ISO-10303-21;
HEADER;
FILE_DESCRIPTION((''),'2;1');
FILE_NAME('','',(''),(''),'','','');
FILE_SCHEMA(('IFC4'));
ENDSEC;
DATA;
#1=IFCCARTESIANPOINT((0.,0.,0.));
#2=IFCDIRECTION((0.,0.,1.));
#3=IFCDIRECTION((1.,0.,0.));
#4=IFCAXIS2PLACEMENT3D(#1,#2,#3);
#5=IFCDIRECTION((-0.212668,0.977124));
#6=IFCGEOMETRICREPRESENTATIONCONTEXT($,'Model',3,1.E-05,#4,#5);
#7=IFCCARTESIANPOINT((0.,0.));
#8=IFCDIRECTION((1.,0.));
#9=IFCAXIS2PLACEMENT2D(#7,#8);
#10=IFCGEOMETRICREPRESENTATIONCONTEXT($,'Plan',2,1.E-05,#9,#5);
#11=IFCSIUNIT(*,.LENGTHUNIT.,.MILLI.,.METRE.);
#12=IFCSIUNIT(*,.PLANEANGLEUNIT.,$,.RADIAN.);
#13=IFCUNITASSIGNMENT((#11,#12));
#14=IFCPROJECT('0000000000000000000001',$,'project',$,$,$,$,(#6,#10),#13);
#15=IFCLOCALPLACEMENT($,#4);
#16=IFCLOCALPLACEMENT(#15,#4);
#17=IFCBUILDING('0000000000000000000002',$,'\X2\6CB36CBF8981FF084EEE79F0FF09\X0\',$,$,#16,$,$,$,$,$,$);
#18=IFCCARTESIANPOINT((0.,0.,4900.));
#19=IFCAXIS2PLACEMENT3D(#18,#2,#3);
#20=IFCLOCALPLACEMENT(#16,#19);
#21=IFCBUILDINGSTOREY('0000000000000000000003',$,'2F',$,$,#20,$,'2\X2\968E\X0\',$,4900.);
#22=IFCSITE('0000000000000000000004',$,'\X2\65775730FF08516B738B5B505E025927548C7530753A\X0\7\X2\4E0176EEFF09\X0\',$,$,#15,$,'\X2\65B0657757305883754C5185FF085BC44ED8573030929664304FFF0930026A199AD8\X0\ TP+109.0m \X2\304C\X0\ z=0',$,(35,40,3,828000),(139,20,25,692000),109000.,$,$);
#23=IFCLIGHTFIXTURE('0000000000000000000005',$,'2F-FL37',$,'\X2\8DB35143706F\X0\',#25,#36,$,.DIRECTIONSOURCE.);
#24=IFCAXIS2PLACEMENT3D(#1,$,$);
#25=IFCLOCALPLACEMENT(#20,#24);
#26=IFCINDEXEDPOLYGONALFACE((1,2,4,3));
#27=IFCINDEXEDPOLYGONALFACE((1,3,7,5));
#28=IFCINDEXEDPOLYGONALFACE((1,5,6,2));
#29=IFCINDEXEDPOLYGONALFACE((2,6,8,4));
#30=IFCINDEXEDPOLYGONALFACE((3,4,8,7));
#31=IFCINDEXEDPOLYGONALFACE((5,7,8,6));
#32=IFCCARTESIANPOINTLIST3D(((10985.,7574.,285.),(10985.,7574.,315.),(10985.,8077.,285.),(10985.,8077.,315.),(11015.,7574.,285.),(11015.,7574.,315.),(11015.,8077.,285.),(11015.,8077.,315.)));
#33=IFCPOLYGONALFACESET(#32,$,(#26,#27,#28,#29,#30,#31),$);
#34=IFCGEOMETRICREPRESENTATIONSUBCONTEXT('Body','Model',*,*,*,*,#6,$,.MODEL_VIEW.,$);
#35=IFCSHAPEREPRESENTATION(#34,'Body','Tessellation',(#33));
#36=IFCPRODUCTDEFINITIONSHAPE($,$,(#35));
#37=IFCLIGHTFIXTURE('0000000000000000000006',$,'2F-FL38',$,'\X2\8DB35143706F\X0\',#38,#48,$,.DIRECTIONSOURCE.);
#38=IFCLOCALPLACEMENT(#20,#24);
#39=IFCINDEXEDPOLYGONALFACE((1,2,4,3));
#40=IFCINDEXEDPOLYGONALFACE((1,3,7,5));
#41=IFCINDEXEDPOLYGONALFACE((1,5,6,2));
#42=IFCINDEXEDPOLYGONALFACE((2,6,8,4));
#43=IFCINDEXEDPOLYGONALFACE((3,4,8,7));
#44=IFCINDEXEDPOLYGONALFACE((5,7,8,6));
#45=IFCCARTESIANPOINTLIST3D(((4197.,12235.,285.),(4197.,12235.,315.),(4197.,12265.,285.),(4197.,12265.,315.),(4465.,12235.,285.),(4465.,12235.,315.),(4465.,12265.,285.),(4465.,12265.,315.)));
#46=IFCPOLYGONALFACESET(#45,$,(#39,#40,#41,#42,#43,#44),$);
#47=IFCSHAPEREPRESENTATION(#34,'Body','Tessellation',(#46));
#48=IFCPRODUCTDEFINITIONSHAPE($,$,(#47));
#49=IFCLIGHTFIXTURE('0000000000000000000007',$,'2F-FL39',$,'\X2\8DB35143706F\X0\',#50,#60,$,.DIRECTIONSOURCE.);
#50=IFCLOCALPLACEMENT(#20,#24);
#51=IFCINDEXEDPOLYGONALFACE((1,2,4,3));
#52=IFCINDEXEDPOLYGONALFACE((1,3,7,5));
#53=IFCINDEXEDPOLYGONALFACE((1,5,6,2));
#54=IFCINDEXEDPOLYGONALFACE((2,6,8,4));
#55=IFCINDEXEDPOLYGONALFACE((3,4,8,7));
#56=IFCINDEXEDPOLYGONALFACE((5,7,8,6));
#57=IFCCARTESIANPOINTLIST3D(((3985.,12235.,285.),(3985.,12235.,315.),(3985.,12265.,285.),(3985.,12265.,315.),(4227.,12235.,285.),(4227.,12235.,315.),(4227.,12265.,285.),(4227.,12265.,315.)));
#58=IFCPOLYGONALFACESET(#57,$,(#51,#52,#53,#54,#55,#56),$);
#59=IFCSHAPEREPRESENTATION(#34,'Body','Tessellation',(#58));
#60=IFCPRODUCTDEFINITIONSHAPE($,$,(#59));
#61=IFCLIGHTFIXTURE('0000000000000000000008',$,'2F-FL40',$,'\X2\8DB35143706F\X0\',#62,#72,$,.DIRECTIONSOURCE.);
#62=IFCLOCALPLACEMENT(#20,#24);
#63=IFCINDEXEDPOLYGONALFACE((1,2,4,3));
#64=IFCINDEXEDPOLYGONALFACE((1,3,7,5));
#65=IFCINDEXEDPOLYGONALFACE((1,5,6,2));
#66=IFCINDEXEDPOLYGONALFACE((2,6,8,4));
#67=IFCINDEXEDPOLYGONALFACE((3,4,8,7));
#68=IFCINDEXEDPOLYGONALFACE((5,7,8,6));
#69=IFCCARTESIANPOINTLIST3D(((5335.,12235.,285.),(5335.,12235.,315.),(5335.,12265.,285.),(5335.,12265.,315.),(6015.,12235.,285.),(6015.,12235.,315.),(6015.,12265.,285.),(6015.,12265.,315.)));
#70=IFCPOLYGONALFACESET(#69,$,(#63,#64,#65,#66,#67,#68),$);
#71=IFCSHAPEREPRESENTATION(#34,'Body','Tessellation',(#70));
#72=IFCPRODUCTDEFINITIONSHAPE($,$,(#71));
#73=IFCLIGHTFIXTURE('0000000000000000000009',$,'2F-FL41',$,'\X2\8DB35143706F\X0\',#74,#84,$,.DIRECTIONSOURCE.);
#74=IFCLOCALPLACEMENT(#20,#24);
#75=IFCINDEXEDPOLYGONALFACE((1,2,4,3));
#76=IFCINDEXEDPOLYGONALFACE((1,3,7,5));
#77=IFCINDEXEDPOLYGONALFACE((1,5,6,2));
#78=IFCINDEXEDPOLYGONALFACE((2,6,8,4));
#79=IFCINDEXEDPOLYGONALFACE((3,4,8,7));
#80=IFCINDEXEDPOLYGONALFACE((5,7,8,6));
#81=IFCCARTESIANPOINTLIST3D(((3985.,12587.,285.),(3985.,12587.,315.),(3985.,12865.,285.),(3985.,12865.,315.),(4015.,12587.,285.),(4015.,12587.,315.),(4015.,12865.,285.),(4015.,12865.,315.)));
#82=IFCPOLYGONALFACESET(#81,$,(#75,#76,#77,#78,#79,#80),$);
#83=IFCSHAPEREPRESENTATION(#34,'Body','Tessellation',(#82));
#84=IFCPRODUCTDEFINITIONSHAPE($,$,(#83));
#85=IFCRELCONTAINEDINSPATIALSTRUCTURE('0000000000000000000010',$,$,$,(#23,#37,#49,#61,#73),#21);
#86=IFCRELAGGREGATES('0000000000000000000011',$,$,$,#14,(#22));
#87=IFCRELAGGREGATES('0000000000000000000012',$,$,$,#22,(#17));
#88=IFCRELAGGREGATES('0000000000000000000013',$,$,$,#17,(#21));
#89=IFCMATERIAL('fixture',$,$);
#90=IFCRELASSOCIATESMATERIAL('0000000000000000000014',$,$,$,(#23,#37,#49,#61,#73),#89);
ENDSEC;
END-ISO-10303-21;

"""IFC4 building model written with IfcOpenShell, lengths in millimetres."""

from ifc_helpers import new_model, si_unit, direction, frame, frame_2d, origin_with_axes, origin_2d_with_axis, place, context, subcontext, project, spatial, rectangle, extrude, material, element, save


model = new_model("IFC4")

# Units and contexts
model_context = context("Model", 3, precision=1e-05, world=origin_with_axes(), true_north=direction((-0.212668, 0.977124)))
plan_context = context("Plan", 2, precision=1e-05, world=origin_2d_with_axis(), true_north=direction((-0.212668, 0.977124)))
body_context = subcontext(model_context, "Body", "Model", "MODEL_VIEW")
ifc_project = project(units=[si_unit("LENGTHUNIT", "METRE", prefix="MILLI"), si_unit("PLANEANGLEUNIT", "RADIAN")], contexts=[model_context, plan_context])

# Site, building, storey
site_placement = place(None, origin_with_axes())
site = spatial("IfcSite", under=ifc_project, at=site_placement, Name="敷地（八王子市大和田町7丁目）", LongName="新敷地境界内（寄付地を除く）。標高 TP+109.0m が z=0", RefLatitude=(35, 40, 3, 828000), RefLongitude=(139, 20, 25, 692000), RefElevation=109000.0)
building_placement = place(site_placement, origin_with_axes())
building = spatial("IfcBuilding", under=site, at=building_placement, Name="河沿要（仮称）")
storey_placement = place(building_placement, frame((0.0, 0.0, 4900.0), z_axis=(0.0, 0.0, 1.0), x_axis=(1.0, 0.0, 0.0)))
storey = spatial("IfcBuildingStorey", under=building, at=storey_placement, Name="2F", LongName="2階", Elevation=4900.0)

# Light fixtures
ifc_material = material(Name="fixture")
light_fixture_1_placement = place(storey_placement, origin_with_axes())
element("IfcLightFixture", 1, at=light_fixture_1_placement, inside=storey, material=ifc_material, Name="2F-FL37", ObjectType="足元灯", PredefinedType="DIRECTIONSOURCE", context=body_context, shape_type="SweptSolid", body=[
    extrude(rectangle(XDim=30.0, YDim=503.0, at=frame_2d((11000.0, 7825.5))), frame((0.0, 0.0, 285.0)), (0.0, 0.0, 1.0), 30.0),
])
light_fixture_2_placement = place(storey_placement, origin_with_axes())
element("IfcLightFixture", 2, at=light_fixture_2_placement, inside=storey, material=ifc_material, Name="2F-FL38", ObjectType="足元灯", PredefinedType="DIRECTIONSOURCE", context=body_context, shape_type="SweptSolid", body=[
    extrude(rectangle(XDim=268.0, YDim=30.0, at=frame_2d((4331.0, 12250.0))), frame((0.0, 0.0, 285.0)), (0.0, 0.0, 1.0), 30.0),
])
light_fixture_3_placement = place(storey_placement, origin_with_axes())
element("IfcLightFixture", 3, at=light_fixture_3_placement, inside=storey, material=ifc_material, Name="2F-FL39", ObjectType="足元灯", PredefinedType="DIRECTIONSOURCE", context=body_context, shape_type="SweptSolid", body=[
    extrude(rectangle(XDim=242.0, YDim=30.0, at=frame_2d((4106.0, 12250.0))), frame((0.0, 0.0, 285.0)), (0.0, 0.0, 1.0), 30.0),
])
light_fixture_4_placement = place(storey_placement, origin_with_axes())
element("IfcLightFixture", 4, at=light_fixture_4_placement, inside=storey, material=ifc_material, Name="2F-FL40", ObjectType="足元灯", PredefinedType="DIRECTIONSOURCE", context=body_context, shape_type="SweptSolid", body=[
    extrude(rectangle(XDim=680.0, YDim=30.0, at=frame_2d((5675.0, 12250.0))), frame((0.0, 0.0, 285.0)), (0.0, 0.0, 1.0), 30.0),
])
light_fixture_5_placement = place(storey_placement, origin_with_axes())
element("IfcLightFixture", 5, at=light_fixture_5_placement, inside=storey, material=ifc_material, Name="2F-FL41", ObjectType="足元灯", PredefinedType="DIRECTIONSOURCE", context=body_context, shape_type="SweptSolid", body=[
    extrude(rectangle(XDim=30.0, YDim=278.0, at=frame_2d((4000.0, 12726.0))), frame((0.0, 0.0, 285.0)), (0.0, 0.0, 1.0), 30.0),
])

save(model, "model.ifc")
